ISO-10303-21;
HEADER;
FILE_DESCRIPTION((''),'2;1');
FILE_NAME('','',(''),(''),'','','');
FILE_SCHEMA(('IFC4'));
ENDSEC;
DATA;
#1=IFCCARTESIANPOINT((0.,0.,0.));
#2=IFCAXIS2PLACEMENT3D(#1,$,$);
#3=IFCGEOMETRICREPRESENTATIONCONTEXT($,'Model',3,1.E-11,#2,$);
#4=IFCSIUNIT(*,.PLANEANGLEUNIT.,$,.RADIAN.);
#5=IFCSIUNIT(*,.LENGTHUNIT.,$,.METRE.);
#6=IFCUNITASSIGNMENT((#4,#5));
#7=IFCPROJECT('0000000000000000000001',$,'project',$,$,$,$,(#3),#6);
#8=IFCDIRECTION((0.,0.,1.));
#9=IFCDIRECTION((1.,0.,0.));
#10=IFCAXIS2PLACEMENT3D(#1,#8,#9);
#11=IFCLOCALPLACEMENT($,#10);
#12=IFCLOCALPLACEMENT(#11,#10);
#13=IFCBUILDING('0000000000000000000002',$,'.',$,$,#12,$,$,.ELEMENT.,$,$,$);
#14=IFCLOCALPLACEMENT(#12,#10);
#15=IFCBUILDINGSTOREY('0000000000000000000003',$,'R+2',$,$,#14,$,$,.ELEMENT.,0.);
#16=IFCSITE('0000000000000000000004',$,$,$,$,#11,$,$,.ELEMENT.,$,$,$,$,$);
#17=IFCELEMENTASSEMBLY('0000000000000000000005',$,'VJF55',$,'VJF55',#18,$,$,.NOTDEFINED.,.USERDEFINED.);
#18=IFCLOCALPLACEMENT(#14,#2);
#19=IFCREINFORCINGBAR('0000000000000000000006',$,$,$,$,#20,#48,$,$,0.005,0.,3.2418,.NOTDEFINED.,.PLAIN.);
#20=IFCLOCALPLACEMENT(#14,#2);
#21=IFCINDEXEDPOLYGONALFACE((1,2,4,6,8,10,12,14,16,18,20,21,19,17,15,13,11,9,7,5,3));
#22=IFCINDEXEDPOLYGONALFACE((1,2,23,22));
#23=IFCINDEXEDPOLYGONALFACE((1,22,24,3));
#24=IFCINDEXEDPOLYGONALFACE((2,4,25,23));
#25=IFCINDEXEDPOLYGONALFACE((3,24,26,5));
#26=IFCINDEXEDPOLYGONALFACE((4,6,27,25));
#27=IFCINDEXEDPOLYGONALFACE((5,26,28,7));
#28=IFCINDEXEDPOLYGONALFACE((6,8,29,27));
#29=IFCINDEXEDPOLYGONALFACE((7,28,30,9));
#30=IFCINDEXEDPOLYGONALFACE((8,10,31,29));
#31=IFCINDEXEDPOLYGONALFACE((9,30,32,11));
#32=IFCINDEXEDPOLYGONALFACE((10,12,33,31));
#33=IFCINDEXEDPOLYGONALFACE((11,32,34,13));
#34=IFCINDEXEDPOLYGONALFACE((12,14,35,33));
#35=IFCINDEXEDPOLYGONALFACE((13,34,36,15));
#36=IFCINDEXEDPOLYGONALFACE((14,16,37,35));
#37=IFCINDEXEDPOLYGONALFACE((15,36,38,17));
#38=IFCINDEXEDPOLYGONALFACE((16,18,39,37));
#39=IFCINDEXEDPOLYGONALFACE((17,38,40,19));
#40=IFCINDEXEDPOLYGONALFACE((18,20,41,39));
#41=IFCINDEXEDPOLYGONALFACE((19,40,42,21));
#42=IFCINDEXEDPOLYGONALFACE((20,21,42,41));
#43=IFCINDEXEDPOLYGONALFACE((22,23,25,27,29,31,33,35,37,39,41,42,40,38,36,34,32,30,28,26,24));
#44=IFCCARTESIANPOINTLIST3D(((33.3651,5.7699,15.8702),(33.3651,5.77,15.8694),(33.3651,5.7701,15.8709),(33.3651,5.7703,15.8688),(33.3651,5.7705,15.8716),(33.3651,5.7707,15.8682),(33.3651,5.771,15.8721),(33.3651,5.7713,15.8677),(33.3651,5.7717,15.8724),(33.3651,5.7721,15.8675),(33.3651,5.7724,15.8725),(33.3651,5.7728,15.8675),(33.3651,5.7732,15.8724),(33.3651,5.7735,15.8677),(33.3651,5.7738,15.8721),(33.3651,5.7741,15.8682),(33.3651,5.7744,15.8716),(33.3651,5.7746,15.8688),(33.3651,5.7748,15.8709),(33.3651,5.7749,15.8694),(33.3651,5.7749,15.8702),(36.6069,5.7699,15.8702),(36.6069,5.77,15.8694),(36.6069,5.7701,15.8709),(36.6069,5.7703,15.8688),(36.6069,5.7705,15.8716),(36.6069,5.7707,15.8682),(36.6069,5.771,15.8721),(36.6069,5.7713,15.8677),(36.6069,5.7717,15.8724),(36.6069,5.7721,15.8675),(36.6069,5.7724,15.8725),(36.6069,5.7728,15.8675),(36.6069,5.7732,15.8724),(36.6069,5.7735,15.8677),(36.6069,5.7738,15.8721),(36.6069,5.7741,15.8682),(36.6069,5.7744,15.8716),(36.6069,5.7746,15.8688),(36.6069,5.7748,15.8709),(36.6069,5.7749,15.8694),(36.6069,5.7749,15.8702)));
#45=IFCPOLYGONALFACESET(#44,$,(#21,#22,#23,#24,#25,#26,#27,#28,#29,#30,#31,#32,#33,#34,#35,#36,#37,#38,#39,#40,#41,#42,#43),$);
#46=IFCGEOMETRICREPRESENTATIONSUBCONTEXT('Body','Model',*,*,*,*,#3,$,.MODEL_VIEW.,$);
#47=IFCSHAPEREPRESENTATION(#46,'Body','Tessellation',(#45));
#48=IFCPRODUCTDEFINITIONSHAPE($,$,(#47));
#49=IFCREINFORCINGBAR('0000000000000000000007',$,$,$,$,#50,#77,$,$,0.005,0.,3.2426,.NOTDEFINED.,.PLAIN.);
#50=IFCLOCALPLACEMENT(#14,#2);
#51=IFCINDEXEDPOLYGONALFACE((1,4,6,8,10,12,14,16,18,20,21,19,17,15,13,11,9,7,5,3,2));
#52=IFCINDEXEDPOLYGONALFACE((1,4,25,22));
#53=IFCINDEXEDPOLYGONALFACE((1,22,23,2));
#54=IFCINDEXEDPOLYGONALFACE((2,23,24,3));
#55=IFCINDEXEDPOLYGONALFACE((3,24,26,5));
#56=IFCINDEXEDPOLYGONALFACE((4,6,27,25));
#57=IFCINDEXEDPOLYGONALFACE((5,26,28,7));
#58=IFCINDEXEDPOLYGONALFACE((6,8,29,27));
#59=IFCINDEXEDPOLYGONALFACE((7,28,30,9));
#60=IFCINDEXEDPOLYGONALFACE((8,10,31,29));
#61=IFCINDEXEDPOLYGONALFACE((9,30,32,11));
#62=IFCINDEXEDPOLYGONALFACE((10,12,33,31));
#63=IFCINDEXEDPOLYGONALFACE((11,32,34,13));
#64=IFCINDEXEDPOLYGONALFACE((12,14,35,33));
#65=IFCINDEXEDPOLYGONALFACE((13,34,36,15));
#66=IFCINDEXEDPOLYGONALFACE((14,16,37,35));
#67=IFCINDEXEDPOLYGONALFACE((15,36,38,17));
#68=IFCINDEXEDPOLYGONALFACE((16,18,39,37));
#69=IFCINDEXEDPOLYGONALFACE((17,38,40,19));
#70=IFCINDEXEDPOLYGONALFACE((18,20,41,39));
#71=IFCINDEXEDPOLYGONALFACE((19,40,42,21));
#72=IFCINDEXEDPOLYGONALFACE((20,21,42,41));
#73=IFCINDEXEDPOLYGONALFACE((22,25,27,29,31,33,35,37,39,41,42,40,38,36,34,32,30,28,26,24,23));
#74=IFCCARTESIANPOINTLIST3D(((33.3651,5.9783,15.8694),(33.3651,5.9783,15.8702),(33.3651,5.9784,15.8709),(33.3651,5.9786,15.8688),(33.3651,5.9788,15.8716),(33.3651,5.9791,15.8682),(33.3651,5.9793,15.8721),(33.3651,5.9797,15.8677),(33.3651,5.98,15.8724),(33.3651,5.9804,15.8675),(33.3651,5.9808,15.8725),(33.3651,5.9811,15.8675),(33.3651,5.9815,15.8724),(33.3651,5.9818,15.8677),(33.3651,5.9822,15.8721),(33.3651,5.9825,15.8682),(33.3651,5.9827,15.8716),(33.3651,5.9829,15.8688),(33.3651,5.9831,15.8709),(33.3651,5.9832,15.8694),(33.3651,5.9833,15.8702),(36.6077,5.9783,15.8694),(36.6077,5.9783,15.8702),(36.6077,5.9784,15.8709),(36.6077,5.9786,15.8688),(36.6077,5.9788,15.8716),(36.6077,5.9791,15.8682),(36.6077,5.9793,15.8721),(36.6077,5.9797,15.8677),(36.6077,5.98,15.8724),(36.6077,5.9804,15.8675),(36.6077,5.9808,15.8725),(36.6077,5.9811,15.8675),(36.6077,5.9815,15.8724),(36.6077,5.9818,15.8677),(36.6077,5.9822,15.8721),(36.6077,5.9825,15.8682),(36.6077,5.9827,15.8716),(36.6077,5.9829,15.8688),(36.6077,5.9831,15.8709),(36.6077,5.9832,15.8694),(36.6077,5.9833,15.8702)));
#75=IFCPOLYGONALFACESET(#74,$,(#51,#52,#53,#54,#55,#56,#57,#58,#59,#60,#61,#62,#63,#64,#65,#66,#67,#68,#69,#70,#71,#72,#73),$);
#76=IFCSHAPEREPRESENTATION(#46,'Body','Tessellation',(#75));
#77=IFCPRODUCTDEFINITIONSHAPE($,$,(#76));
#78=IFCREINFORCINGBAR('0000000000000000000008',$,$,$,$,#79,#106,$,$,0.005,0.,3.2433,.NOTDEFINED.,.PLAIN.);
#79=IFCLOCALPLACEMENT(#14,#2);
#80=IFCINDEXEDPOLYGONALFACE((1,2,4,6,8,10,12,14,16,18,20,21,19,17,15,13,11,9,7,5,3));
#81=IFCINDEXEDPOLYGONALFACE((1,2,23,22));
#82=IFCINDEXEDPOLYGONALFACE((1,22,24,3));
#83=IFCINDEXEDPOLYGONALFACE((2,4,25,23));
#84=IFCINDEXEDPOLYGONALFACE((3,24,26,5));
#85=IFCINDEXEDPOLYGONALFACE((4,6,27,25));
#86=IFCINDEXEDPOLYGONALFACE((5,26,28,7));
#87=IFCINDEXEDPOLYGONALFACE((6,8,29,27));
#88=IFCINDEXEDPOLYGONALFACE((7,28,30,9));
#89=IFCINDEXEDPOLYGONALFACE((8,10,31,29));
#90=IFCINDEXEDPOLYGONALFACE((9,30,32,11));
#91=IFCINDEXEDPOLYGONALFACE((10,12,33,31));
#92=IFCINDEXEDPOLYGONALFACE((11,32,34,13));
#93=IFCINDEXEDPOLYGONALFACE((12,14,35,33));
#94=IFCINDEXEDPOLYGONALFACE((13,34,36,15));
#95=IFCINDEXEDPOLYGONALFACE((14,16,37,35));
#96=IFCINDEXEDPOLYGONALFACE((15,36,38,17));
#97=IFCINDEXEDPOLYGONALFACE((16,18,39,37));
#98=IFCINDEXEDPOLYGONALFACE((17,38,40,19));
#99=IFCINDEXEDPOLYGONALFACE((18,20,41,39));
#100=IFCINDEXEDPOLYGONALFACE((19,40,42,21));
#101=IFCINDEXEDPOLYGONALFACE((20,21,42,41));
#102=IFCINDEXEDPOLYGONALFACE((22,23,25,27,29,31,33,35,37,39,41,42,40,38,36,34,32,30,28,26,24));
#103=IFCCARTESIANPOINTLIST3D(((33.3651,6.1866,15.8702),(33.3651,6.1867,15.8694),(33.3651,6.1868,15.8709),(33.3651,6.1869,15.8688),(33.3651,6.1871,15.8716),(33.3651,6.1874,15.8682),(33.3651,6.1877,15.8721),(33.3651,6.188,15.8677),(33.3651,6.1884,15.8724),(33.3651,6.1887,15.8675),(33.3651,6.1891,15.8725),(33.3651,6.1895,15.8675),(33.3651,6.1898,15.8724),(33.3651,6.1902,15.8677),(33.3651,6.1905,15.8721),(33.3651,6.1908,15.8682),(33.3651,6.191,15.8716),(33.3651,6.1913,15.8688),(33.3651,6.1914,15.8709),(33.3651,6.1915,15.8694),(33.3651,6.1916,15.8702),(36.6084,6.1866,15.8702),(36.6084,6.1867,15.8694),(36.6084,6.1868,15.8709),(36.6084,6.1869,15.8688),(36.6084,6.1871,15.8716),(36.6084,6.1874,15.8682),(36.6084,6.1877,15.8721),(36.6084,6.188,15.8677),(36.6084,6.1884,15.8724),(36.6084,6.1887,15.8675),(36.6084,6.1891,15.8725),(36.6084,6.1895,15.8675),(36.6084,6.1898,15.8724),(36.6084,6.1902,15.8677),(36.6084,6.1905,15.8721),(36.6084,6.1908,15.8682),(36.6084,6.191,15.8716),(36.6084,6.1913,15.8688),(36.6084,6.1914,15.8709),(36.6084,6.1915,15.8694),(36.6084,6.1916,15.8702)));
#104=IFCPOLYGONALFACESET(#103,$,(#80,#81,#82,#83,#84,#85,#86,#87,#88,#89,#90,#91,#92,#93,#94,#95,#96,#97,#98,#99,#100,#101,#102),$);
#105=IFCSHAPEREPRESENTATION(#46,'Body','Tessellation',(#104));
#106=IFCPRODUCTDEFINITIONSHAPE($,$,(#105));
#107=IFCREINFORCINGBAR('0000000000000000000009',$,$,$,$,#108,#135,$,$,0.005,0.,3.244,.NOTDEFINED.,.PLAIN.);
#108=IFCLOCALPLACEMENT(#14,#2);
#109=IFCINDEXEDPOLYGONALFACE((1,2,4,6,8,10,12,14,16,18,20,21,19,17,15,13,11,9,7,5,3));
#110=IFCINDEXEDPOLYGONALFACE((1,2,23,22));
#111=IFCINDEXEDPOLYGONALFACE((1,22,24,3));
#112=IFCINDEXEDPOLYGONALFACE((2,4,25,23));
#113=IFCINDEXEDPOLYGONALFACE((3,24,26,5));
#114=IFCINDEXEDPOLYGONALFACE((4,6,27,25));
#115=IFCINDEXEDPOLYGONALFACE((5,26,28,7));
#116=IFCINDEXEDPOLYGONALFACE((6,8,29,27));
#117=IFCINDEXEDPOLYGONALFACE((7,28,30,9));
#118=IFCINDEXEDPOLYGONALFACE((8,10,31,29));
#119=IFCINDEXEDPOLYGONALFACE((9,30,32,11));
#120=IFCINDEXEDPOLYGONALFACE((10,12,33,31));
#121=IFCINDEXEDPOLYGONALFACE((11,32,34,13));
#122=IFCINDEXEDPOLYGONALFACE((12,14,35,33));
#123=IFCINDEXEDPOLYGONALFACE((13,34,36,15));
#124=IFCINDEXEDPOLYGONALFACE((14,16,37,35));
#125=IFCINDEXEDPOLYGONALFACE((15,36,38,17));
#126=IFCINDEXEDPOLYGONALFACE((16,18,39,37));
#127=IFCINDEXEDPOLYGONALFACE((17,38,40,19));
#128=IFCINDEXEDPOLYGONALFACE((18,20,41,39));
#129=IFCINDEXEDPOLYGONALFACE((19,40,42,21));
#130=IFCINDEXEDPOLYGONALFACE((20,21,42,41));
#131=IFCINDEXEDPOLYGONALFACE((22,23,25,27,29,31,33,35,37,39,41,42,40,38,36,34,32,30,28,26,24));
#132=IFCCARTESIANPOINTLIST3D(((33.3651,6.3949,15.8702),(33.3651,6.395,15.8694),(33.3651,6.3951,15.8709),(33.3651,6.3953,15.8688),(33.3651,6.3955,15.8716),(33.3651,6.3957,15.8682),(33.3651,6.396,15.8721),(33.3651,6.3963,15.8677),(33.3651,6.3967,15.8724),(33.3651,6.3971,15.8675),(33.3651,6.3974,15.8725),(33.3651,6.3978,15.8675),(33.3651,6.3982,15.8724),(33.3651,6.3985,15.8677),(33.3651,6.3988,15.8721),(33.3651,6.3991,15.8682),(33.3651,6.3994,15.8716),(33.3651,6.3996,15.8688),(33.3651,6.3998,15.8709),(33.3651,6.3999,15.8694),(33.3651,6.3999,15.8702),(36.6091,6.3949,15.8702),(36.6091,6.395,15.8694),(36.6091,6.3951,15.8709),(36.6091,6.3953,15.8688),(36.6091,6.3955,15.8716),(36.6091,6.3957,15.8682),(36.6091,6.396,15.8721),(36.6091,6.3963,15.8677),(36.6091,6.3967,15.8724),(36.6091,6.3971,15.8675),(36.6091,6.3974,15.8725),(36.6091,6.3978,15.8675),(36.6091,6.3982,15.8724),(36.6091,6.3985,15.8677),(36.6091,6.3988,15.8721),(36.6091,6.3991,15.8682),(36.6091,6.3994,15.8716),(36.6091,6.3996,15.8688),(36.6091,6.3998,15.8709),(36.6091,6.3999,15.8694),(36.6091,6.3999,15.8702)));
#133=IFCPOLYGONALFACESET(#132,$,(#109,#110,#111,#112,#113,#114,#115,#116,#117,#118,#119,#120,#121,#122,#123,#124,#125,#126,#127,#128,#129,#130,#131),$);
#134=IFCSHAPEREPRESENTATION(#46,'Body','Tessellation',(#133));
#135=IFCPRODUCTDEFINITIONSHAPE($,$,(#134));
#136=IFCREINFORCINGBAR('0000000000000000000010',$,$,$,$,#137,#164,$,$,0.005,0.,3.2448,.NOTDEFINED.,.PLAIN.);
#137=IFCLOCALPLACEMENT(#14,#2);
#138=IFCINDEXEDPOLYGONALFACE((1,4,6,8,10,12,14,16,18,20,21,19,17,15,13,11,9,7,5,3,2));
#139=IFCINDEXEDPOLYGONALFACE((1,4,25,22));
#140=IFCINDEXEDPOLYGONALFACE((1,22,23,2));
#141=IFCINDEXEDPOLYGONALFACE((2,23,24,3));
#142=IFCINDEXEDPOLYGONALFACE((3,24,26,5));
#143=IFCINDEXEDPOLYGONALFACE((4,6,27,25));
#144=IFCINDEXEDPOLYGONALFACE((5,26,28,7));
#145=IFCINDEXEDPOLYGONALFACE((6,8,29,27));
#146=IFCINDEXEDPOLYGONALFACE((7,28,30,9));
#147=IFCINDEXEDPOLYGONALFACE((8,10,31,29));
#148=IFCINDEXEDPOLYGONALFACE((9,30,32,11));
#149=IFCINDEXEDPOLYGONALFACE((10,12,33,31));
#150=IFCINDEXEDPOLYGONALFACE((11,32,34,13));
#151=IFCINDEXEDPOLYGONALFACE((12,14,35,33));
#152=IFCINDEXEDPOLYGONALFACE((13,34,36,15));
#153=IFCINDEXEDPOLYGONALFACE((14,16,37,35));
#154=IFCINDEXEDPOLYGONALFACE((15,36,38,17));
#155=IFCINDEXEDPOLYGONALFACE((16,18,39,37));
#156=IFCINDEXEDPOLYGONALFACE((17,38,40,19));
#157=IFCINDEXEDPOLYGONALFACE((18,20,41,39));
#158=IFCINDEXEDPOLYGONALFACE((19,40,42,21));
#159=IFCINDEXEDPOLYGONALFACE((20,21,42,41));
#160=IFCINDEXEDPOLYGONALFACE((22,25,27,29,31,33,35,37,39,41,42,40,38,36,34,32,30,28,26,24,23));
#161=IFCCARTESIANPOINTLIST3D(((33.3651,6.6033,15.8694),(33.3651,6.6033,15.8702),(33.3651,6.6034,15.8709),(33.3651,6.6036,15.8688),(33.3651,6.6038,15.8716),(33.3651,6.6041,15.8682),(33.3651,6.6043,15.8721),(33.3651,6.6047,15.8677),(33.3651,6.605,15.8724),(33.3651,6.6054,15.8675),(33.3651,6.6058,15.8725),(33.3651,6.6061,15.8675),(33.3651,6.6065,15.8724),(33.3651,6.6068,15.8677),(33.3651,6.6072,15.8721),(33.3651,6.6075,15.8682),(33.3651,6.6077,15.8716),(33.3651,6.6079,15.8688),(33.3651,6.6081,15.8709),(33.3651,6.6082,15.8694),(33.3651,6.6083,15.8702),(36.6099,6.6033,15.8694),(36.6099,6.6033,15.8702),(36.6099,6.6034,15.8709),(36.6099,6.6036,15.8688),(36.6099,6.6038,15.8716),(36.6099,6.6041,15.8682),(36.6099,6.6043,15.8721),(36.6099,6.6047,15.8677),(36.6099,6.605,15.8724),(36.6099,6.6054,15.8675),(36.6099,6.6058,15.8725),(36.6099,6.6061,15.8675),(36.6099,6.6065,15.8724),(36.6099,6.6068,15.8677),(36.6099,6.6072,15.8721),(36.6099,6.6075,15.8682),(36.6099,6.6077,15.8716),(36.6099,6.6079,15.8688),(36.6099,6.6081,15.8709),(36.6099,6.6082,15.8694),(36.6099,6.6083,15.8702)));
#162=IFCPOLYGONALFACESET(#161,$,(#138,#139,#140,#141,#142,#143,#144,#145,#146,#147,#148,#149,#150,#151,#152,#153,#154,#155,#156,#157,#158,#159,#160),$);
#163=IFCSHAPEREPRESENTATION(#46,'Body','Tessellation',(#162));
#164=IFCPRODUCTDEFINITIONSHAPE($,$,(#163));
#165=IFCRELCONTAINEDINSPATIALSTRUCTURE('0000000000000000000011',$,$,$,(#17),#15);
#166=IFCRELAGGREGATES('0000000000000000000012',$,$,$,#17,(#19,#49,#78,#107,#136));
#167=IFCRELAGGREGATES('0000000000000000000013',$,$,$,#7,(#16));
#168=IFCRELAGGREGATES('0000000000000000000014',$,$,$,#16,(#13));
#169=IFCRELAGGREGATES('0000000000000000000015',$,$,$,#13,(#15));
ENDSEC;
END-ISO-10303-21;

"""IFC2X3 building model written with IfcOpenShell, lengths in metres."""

from ifc_helpers import new_model, entity, si_unit, origin, origin_with_axes, place, context, subcontext, project, spatial, shape, element, aggregate, save


model = new_model("IFC2X3")

# Units and contexts
model_context = context("Model", 3, precision=1e-11, world=origin())
body_context = subcontext(model_context, "Body", "Model", "MODEL_VIEW")
ifc_project = project(units=[si_unit("PLANEANGLEUNIT", "RADIAN"), si_unit("LENGTHUNIT", "METRE")], contexts=[model_context])

# Site, building, storey
site_placement = place(None, origin_with_axes())
site = spatial("IfcSite", under=ifc_project, at=site_placement, CompositionType="ELEMENT")
building_placement = place(site_placement, origin_with_axes())
building = spatial("IfcBuilding", under=site, at=building_placement, Name=".", CompositionType="ELEMENT")
storey_placement = place(building_placement, origin_with_axes())
storey = spatial("IfcBuildingStorey", under=building, at=storey_placement, Name="R+2", CompositionType="ELEMENT", Elevation=0.0)

# Element assembly, reinforcing bars
assembly_1_placement = place(storey_placement, origin_with_axes())
assembly_1 = element("IfcElementAssembly", 1, at=assembly_1_placement, inside=storey, Name="VJF55", ObjectType="VJF55", AssemblyPlace="NOTDEFINED", PredefinedType="USERDEFINED")
reinforcing_bar_1_placement = place(assembly_1_placement, origin_with_axes())
reinforcing_bar_1 = element("IfcReinforcingBar", 2, at=reinforcing_bar_1_placement, BarLength=3.2418, BarRole="NOTDEFINED", BarSurface="PLAIN", CrossSectionArea=0.0, NominalDiameter=0.005, shapes=[
    shape(body_context, "Body", "AdvancedSweptSolid", [entity("IfcSweptDiskSolid", entity("IfcPolyline", [entity("IfcCartesianPoint", [33.3651, 5.7724, 15.87]), entity("IfcCartesianPoint", [36.6069, 5.7724, 15.87])]), 0.0025, None, 0.0, 3.2418)]),
    shape(body_context, "Body", "AdvancedSweptSolid", [entity("IfcSweptDiskSolid", entity("IfcPolyline", [entity("IfcCartesianPoint", [33.3651, 5.7724, 15.87]), entity("IfcCartesianPoint", [36.6069, 5.7724, 15.87])]), 0.0025, None, 0.0, 3.2418)]),
])
reinforcing_bar_2_placement = place(assembly_1_placement, origin_with_axes())
reinforcing_bar_2 = element("IfcReinforcingBar", 3, at=reinforcing_bar_2_placement, BarLength=3.2426, BarRole="NOTDEFINED", BarSurface="PLAIN", CrossSectionArea=0.0, NominalDiameter=0.005, shapes=[
    shape(body_context, "Body", "AdvancedSweptSolid", [entity("IfcSweptDiskSolid", entity("IfcPolyline", [entity("IfcCartesianPoint", [33.3651, 5.9808, 15.87]), entity("IfcCartesianPoint", [36.6077, 5.9808, 15.87])]), 0.0025, None, 0.0, 3.2426)]),
    shape(body_context, "Body", "AdvancedSweptSolid", [entity("IfcSweptDiskSolid", entity("IfcPolyline", [entity("IfcCartesianPoint", [33.3651, 5.9808, 15.87]), entity("IfcCartesianPoint", [36.6077, 5.9808, 15.87])]), 0.0025, None, 0.0, 3.2426)]),
])
reinforcing_bar_3_placement = place(assembly_1_placement, origin_with_axes())
reinforcing_bar_3 = element("IfcReinforcingBar", 4, at=reinforcing_bar_3_placement, BarLength=3.2433, BarRole="NOTDEFINED", BarSurface="PLAIN", CrossSectionArea=0.0, NominalDiameter=0.005, shapes=[
    shape(body_context, "Body", "AdvancedSweptSolid", [entity("IfcSweptDiskSolid", entity("IfcPolyline", [entity("IfcCartesianPoint", [33.3651, 6.1891, 15.87]), entity("IfcCartesianPoint", [36.6084, 6.1891, 15.87])]), 0.0025, None, 0.0, 3.2433)]),
    shape(body_context, "Body", "AdvancedSweptSolid", [entity("IfcSweptDiskSolid", entity("IfcPolyline", [entity("IfcCartesianPoint", [33.3651, 6.1891, 15.87]), entity("IfcCartesianPoint", [36.6084, 6.1891, 15.87])]), 0.0025, None, 0.0, 3.2433)]),
])
reinforcing_bar_4_placement = place(assembly_1_placement, origin_with_axes())
reinforcing_bar_4 = element("IfcReinforcingBar", 5, at=reinforcing_bar_4_placement, BarLength=3.244, BarRole="NOTDEFINED", BarSurface="PLAIN", CrossSectionArea=0.0, NominalDiameter=0.005, shapes=[
    shape(body_context, "Body", "AdvancedSweptSolid", [entity("IfcSweptDiskSolid", entity("IfcPolyline", [entity("IfcCartesianPoint", [33.3651, 6.3974, 15.87]), entity("IfcCartesianPoint", [36.6091, 6.3974, 15.87])]), 0.0025, None, 0.0, 3.244)]),
    shape(body_context, "Body", "AdvancedSweptSolid", [entity("IfcSweptDiskSolid", entity("IfcPolyline", [entity("IfcCartesianPoint", [33.3651, 6.3974, 15.87]), entity("IfcCartesianPoint", [36.6091, 6.3974, 15.87])]), 0.0025, None, 0.0, 3.244)]),
])
reinforcing_bar_5_placement = place(assembly_1_placement, origin_with_axes())
reinforcing_bar_5 = element("IfcReinforcingBar", 6, at=reinforcing_bar_5_placement, BarLength=3.2448, BarRole="NOTDEFINED", BarSurface="PLAIN", CrossSectionArea=0.0, NominalDiameter=0.005, shapes=[
    shape(body_context, "Body", "AdvancedSweptSolid", [entity("IfcSweptDiskSolid", entity("IfcPolyline", [entity("IfcCartesianPoint", [33.3651, 6.6058, 15.87]), entity("IfcCartesianPoint", [36.6099, 6.6058, 15.87])]), 0.0025, None, 0.0, 3.2448)]),
    shape(body_context, "Body", "AdvancedSweptSolid", [entity("IfcSweptDiskSolid", entity("IfcPolyline", [entity("IfcCartesianPoint", [33.3651, 6.6058, 15.87]), entity("IfcCartesianPoint", [36.6099, 6.6058, 15.87])]), 0.0025, None, 0.0, 3.2448)]),
])
aggregate(assembly_1, [reinforcing_bar_1, reinforcing_bar_2, reinforcing_bar_3, reinforcing_bar_4, reinforcing_bar_5])

save(model, "model.ifc")
